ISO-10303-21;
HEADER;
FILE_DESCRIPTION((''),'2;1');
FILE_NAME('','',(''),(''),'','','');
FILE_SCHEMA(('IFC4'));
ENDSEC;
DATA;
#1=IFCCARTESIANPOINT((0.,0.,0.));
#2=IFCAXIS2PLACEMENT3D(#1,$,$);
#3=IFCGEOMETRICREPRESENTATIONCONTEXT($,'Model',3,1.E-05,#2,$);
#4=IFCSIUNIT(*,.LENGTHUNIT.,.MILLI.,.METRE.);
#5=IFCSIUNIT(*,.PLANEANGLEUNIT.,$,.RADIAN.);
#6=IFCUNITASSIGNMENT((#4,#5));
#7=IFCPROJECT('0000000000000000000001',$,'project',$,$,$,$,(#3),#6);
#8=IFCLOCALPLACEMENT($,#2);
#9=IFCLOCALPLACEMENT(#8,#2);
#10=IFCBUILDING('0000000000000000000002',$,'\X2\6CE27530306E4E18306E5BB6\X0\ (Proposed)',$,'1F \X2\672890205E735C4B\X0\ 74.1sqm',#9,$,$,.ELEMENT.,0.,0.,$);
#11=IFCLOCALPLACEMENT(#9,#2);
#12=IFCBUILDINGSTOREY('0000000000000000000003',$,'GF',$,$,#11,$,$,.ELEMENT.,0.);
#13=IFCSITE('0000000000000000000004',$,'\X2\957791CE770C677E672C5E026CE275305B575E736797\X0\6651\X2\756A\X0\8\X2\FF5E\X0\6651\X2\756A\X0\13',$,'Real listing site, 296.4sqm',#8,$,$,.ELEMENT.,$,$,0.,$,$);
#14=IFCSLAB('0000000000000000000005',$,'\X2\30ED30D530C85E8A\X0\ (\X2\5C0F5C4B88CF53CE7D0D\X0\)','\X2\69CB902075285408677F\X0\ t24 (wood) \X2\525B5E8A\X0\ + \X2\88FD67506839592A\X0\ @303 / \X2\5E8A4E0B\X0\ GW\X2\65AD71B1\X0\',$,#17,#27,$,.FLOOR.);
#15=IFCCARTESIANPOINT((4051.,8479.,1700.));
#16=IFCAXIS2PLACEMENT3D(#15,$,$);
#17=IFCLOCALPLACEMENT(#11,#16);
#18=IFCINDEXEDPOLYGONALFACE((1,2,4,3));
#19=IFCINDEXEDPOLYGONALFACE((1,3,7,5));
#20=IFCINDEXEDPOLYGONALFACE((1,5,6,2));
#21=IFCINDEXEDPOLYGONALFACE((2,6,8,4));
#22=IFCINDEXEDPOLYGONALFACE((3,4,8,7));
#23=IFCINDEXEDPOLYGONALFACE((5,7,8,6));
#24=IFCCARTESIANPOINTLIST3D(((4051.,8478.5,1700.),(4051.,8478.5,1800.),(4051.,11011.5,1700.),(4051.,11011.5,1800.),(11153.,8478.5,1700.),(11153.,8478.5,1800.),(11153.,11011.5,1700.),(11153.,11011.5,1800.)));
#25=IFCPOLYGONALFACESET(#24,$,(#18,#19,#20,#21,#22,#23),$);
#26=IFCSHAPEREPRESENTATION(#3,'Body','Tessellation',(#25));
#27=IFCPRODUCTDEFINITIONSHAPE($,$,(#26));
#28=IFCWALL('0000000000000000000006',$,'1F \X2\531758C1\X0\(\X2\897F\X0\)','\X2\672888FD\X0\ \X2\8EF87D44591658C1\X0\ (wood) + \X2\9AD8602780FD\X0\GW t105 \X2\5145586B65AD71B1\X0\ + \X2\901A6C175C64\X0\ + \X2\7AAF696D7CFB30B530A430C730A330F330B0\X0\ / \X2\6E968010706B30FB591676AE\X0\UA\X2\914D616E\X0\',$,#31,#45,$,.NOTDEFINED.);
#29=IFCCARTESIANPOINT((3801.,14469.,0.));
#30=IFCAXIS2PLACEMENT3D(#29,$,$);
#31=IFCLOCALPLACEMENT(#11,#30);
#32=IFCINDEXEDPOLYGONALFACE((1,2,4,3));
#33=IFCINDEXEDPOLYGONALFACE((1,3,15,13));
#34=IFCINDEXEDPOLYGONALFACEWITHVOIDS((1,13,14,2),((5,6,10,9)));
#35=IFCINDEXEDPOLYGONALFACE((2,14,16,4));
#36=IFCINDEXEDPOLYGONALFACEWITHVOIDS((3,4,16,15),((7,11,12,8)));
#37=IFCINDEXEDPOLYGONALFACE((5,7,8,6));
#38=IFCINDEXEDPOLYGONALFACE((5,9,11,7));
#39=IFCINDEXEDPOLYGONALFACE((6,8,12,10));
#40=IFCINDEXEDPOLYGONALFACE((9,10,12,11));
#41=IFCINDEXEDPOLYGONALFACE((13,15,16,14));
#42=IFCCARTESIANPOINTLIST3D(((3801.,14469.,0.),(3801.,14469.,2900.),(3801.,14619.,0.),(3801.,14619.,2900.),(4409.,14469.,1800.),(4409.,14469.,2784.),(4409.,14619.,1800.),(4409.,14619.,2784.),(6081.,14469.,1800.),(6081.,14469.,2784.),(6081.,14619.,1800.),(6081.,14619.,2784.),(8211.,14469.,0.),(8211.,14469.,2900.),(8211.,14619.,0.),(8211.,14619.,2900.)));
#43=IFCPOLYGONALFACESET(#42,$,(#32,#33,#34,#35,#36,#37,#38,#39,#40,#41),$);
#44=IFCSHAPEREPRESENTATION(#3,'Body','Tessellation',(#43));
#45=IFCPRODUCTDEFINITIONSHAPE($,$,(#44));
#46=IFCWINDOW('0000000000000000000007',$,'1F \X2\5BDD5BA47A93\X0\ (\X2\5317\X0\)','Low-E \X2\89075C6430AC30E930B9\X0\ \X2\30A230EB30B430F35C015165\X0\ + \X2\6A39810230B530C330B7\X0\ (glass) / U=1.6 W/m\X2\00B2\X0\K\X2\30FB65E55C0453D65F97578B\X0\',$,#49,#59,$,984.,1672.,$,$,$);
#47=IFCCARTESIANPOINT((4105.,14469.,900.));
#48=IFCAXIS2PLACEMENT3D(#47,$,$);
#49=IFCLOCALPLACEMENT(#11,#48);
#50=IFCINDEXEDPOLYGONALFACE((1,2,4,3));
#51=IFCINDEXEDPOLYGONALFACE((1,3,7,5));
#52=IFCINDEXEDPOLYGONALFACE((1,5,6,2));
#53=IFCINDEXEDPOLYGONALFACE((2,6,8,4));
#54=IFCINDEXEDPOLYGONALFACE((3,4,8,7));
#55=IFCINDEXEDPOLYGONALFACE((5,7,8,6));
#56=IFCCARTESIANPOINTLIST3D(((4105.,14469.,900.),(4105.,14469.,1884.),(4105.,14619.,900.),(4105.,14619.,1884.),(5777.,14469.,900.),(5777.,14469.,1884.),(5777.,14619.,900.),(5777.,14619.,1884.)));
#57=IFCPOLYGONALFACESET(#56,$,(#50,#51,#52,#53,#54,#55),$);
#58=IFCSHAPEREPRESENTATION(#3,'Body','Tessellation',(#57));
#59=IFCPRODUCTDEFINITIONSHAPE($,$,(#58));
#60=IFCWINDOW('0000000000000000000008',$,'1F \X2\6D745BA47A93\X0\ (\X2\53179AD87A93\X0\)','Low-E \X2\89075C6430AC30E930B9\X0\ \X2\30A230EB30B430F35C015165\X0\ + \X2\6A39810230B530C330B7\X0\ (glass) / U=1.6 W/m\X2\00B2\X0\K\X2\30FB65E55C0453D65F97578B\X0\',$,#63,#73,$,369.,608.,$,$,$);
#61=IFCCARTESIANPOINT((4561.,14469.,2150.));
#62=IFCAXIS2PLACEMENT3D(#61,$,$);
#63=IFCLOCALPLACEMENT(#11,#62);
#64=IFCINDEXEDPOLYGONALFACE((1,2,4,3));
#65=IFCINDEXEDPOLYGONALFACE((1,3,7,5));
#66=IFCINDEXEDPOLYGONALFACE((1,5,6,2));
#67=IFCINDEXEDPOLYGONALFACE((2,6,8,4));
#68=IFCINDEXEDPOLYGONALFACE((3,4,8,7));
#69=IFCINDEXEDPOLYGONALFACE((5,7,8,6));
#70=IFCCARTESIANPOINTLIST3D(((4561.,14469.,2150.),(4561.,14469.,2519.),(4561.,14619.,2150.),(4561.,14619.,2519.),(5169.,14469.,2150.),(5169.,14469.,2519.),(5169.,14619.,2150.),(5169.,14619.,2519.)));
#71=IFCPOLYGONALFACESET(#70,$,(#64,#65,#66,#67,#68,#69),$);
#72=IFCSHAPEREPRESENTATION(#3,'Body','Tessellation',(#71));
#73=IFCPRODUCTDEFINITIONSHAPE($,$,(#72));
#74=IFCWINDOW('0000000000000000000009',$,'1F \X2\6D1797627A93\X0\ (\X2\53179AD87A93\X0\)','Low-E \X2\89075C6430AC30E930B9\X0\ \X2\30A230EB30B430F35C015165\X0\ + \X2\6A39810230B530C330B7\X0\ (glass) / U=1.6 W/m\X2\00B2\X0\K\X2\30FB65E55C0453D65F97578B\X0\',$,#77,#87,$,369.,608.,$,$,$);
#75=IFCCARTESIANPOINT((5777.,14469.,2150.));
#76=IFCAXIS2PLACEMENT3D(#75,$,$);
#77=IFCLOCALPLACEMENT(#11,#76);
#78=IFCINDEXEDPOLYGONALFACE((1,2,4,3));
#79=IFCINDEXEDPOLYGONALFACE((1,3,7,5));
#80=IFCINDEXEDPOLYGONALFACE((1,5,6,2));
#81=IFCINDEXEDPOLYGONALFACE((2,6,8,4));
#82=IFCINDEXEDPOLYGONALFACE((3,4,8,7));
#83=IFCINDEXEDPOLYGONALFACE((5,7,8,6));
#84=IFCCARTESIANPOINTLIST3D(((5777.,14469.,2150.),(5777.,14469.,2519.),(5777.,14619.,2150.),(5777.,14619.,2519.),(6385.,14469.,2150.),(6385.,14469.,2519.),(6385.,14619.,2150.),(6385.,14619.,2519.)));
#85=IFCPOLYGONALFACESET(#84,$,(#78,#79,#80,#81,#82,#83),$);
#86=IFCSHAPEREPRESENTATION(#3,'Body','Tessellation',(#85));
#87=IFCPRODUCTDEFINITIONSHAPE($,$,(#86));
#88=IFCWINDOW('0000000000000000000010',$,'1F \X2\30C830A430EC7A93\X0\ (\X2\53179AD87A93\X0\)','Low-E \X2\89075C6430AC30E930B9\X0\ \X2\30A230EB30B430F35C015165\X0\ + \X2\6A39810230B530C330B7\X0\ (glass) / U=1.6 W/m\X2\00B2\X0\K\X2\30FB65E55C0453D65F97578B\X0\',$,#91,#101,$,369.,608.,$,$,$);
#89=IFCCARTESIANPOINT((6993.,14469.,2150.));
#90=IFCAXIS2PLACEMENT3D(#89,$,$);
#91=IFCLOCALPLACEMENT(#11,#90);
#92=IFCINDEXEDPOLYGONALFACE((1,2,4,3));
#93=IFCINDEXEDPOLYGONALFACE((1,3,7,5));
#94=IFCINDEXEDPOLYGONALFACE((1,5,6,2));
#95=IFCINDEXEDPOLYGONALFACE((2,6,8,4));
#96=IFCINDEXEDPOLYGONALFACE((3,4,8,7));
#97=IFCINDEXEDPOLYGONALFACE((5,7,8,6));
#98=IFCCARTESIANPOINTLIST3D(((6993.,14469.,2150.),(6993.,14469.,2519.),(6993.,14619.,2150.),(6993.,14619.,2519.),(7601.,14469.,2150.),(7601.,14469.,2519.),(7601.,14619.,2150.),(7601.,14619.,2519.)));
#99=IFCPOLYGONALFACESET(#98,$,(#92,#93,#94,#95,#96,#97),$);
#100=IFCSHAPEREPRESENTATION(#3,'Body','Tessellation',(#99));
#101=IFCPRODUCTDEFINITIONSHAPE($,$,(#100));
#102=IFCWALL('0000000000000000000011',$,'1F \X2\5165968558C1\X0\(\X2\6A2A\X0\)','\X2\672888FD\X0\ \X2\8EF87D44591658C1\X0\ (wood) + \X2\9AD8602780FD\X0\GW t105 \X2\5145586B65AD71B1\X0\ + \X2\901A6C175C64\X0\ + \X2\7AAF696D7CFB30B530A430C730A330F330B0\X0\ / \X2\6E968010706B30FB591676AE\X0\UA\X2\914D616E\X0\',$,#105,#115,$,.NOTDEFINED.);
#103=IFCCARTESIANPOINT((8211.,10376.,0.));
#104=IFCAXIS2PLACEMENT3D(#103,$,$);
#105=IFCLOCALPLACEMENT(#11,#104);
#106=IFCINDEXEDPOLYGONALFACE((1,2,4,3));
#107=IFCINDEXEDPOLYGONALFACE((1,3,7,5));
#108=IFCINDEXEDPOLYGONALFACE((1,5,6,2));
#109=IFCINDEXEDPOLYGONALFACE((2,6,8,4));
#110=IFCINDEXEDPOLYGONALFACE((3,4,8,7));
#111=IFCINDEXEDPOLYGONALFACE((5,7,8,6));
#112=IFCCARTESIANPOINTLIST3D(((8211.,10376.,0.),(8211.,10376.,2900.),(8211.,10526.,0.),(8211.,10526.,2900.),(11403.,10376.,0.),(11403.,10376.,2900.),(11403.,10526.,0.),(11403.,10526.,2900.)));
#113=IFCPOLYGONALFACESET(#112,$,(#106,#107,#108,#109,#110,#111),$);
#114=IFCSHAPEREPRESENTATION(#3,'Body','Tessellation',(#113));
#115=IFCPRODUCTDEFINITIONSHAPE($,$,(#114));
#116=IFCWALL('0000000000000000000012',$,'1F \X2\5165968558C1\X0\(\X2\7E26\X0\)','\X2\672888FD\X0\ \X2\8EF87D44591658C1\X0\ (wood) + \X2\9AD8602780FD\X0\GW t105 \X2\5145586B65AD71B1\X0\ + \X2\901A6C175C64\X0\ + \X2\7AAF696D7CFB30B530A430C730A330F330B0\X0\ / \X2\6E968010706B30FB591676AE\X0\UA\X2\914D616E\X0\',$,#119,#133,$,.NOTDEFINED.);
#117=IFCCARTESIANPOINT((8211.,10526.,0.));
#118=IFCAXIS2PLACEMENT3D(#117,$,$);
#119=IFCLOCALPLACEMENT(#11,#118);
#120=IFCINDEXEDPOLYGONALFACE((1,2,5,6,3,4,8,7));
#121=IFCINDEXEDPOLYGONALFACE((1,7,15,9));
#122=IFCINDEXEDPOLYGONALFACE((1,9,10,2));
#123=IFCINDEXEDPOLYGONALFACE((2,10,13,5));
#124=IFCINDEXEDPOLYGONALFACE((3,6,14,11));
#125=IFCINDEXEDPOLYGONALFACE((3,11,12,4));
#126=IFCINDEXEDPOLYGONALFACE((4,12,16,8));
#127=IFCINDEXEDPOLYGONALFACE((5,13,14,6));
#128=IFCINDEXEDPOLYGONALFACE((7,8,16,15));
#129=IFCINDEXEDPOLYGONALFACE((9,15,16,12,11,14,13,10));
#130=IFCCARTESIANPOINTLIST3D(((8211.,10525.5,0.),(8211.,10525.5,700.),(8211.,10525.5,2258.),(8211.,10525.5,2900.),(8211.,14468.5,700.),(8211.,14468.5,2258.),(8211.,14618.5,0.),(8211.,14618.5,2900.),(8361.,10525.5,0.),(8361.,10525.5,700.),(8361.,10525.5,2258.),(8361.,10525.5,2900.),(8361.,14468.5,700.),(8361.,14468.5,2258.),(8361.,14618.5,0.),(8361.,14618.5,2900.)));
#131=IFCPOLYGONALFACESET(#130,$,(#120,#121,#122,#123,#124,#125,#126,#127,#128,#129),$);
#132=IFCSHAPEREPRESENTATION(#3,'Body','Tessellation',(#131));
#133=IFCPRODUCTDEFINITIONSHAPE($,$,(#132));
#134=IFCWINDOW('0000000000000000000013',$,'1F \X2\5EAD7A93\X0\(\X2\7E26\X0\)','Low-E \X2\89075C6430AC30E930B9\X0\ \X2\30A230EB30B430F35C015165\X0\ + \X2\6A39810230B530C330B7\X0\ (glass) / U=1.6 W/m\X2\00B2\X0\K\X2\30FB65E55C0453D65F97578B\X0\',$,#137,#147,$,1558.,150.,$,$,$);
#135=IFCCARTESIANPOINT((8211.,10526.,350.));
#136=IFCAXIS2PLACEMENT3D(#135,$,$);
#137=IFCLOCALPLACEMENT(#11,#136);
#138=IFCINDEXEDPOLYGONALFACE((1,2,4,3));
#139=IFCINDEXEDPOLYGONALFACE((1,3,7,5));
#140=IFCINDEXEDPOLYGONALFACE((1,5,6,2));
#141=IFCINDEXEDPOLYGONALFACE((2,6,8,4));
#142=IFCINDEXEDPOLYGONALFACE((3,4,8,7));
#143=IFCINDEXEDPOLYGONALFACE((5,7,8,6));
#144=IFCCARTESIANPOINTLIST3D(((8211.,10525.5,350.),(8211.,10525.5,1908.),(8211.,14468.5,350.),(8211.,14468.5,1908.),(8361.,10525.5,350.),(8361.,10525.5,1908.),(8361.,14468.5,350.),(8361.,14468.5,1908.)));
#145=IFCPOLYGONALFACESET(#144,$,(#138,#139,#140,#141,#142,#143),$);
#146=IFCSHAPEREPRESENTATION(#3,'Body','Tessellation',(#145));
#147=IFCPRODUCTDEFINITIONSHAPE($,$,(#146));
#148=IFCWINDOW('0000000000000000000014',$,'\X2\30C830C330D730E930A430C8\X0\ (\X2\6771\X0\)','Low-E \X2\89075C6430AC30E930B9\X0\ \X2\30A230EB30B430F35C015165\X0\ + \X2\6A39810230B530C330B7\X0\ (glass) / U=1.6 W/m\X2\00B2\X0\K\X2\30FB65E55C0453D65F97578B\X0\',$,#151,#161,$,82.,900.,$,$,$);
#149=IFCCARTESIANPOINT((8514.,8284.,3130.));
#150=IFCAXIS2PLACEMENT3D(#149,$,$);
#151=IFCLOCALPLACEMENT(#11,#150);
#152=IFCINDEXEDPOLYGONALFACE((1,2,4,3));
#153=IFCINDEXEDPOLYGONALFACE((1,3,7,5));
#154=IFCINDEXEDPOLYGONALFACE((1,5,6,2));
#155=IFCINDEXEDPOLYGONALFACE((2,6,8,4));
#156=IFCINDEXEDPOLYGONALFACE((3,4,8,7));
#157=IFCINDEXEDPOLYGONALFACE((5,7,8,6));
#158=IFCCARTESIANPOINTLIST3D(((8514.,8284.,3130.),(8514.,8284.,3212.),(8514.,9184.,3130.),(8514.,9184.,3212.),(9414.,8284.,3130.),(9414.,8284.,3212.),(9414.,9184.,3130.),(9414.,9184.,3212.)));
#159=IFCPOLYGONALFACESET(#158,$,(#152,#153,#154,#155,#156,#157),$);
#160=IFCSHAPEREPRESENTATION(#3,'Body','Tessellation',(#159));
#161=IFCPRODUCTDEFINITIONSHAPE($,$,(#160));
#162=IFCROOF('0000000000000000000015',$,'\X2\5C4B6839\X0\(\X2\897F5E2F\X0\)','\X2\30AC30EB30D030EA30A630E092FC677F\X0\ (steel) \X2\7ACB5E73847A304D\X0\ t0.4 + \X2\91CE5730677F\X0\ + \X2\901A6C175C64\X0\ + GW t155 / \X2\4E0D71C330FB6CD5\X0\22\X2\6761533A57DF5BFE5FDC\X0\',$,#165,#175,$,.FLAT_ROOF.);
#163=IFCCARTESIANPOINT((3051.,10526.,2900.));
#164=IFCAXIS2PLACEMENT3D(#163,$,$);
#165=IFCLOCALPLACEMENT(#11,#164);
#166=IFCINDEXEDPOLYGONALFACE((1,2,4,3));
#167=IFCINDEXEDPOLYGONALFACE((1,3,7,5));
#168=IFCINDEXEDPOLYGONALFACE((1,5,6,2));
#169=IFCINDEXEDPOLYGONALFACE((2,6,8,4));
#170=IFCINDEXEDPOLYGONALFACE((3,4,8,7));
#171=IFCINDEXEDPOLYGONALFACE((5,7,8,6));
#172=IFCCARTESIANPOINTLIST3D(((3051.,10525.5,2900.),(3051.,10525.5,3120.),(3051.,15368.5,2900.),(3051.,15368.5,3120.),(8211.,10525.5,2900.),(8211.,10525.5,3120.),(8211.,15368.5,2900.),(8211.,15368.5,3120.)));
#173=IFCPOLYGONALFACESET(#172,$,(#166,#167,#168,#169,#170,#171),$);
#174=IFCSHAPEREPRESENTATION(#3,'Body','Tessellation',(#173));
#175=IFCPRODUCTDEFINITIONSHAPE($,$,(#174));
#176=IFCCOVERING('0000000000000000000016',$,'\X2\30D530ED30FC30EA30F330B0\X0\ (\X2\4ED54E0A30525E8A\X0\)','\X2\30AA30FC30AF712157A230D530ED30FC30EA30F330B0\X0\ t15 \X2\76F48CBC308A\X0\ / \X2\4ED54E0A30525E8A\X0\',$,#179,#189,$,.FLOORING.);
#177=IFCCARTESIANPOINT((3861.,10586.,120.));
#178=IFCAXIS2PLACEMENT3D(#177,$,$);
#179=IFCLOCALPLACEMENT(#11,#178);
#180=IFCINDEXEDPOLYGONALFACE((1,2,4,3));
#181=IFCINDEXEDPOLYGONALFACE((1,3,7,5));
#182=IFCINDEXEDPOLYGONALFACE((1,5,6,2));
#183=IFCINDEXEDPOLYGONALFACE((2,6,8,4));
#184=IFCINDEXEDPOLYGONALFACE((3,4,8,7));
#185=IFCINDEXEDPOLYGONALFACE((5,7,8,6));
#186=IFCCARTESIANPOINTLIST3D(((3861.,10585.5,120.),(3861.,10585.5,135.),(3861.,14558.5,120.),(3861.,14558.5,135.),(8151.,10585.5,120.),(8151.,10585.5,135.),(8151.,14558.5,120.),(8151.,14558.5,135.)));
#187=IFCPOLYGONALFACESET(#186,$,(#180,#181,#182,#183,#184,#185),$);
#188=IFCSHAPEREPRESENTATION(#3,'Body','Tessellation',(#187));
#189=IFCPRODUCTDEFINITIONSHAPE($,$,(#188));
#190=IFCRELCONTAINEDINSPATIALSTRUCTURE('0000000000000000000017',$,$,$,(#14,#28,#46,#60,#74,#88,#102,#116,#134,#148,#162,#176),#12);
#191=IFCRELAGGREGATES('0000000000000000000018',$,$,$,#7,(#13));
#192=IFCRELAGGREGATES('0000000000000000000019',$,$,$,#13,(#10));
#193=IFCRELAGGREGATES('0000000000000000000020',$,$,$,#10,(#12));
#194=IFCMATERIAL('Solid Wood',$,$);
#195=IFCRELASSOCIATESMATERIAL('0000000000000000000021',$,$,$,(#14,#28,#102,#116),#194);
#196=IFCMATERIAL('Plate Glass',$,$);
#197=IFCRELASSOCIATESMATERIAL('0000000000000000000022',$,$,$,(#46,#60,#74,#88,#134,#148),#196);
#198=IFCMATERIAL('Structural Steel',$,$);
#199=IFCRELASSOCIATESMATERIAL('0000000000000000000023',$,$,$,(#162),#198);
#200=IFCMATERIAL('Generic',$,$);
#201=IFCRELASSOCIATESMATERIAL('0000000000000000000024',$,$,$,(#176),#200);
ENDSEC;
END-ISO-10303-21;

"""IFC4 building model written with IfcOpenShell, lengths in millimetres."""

from ifc_helpers import new_model, si_unit, frame, frame_2d, origin, place, context, project, spatial, rectangle, extrude, material, element, fill, save


model = new_model("IFC4")

# Units and contexts
model_context = context("Model", 3, precision=1e-05, world=origin())
ifc_project = project(units=[si_unit("LENGTHUNIT", "METRE", prefix="MILLI"), si_unit("PLANEANGLEUNIT", "RADIAN")], contexts=[model_context])

# Site, building, storey
site_placement = place(None, origin())
site = spatial("IfcSite", under=ifc_project, at=site_placement, Name="長野県松本市波田字平林6651番8～6651番13", ObjectType="Real listing site, 296.4sqm", CompositionType="ELEMENT", RefElevation=0.0)
building_placement = place(site_placement, origin())
building = spatial("IfcBuilding", under=site, at=building_placement, Name="波田の丘の家 (Proposed)", ObjectType="1F 木造平屋 74.1sqm", CompositionType="ELEMENT", ElevationOfRefHeight=0.0, ElevationOfTerrain=0.0)
storey_placement = place(building_placement, origin())
storey = spatial("IfcBuildingStorey", under=building, at=storey_placement, Name="GF", CompositionType="ELEMENT", Elevation=0.0)

# Slab
ifc_material_1 = material(Name="Solid Wood")
slab_1_placement = place(storey_placement, frame((4051.0, 8479.0, 1700.0)))
element("IfcSlab", 1, at=slab_1_placement, inside=storey, material=ifc_material_1, Name="ロフト床 (小屋裏収納)", Description="構造用合板 t24 (wood) 剛床 + 製材根太 @303 / 床下 GW断熱", PredefinedType="FLOOR", context=model_context, shape_type="SweptSolid", body=[
    extrude(rectangle(XDim=7102.0, YDim=2533.0, at=frame_2d((3551.0, 1266.0))), frame((4051.0, 8479.0, 1700.0)), (0.0, 0.0, 1.0), 100.0),
])

# Wall, openings, windows
wall_1_placement = place(storey_placement, frame((3801.0, 14469.0, 0.0)))
wall_1 = element("IfcWall", 2, at=wall_1_placement, inside=storey, material=ifc_material_1, Name="1F 北壁(西)", Description="木製 軸組外壁 (wood) + 高性能GW t105 充填断熱 + 通気層 + 窯業系サイディング / 準耐火・外皮UA配慮", PredefinedType="NOTDEFINED", context=model_context, shape_type="SweptSolid", body=[
    extrude(rectangle(XDim=4410.0, YDim=150.0, at=frame_2d((2205.0, 75.0))), frame((3801.0, 14469.0, 0.0)), (0.0, 0.0, 1.0), 2900.0),
])
opening_1_placement = place(storey_placement, frame((4105.0, 14469.0, 900.0)))
opening_1 = element("IfcOpeningElement", 3, at=opening_1_placement, cuts=wall_1, PredefinedType="NOTDEFINED", context=model_context, shape_type="SweptSolid", body=[
    extrude(rectangle(XDim=1672.0, YDim=150.0, at=frame_2d((836.0, 75.0))), frame((4105.0, 14469.0, 900.0)), (0.0, 0.0, 1.0), 984.0),
])
opening_2_placement = place(storey_placement, frame((4561.0, 14469.0, 2150.0)))
opening_2 = element("IfcOpeningElement", 4, at=opening_2_placement, cuts=wall_1, PredefinedType="NOTDEFINED", context=model_context, shape_type="SweptSolid", body=[
    extrude(rectangle(XDim=608.0, YDim=150.0, at=frame_2d((304.0, 75.0))), frame((4561.0, 14469.0, 2150.0)), (0.0, 0.0, 1.0), 369.0),
])
opening_3_placement = place(storey_placement, frame((5777.0, 14469.0, 2150.0)))
opening_3 = element("IfcOpeningElement", 5, at=opening_3_placement, cuts=wall_1, PredefinedType="NOTDEFINED", context=model_context, shape_type="SweptSolid", body=[
    extrude(rectangle(XDim=608.0, YDim=150.0, at=frame_2d((304.0, 75.0))), frame((5777.0, 14469.0, 2150.0)), (0.0, 0.0, 1.0), 369.0),
])
opening_4_placement = place(storey_placement, frame((6993.0, 14469.0, 2150.0)))
opening_4 = element("IfcOpeningElement", 6, at=opening_4_placement, cuts=wall_1, PredefinedType="NOTDEFINED", context=model_context, shape_type="SweptSolid", body=[
    extrude(rectangle(XDim=608.0, YDim=150.0, at=frame_2d((304.0, 75.0))), frame((6993.0, 14469.0, 2150.0)), (0.0, 0.0, 1.0), 369.0),
])
ifc_material_2 = material(Name="Plate Glass")
window_1_placement = place(storey_placement, frame((4105.0, 14469.0, 900.0)))
window_1 = element("IfcWindow", 7, at=window_1_placement, inside=storey, material=ifc_material_2, Name="1F 寝室窓 (北)", Description="Low-E 複層ガラス アルゴン封入 + 樹脂サッシ (glass) / U=1.6 W/m²K・日射取得型", OverallHeight=984.0, OverallWidth=1672.0, context=model_context, shape_type="SweptSolid", body=[
    extrude(rectangle(XDim=1672.0, YDim=150.0, at=frame_2d((836.0, 75.0))), frame((4105.0, 14469.0, 900.0)), (0.0, 0.0, 1.0), 984.0),
])
fill(opening_1, window_1)
window_2_placement = place(storey_placement, frame((4561.0, 14469.0, 2150.0)))
window_2 = element("IfcWindow", 8, at=window_2_placement, inside=storey, material=ifc_material_2, Name="1F 浴室窓 (北高窓)", Description="Low-E 複層ガラス アルゴン封入 + 樹脂サッシ (glass) / U=1.6 W/m²K・日射取得型", OverallHeight=369.0, OverallWidth=608.0, context=model_context, shape_type="SweptSolid", body=[
    extrude(rectangle(XDim=608.0, YDim=150.0, at=frame_2d((304.0, 75.0))), frame((4561.0, 14469.0, 2150.0)), (0.0, 0.0, 1.0), 369.0),
])
fill(opening_2, window_2)
window_3_placement = place(storey_placement, frame((5777.0, 14469.0, 2150.0)))
window_3 = element("IfcWindow", 9, at=window_3_placement, inside=storey, material=ifc_material_2, Name="1F 洗面窓 (北高窓)", Description="Low-E 複層ガラス アルゴン封入 + 樹脂サッシ (glass) / U=1.6 W/m²K・日射取得型", OverallHeight=369.0, OverallWidth=608.0, context=model_context, shape_type="SweptSolid", body=[
    extrude(rectangle(XDim=608.0, YDim=150.0, at=frame_2d((304.0, 75.0))), frame((5777.0, 14469.0, 2150.0)), (0.0, 0.0, 1.0), 369.0),
])
fill(opening_3, window_3)
window_4_placement = place(storey_placement, frame((6993.0, 14469.0, 2150.0)))
window_4 = element("IfcWindow", 10, at=window_4_placement, inside=storey, material=ifc_material_2, Name="1F トイレ窓 (北高窓)", Description="Low-E 複層ガラス アルゴン封入 + 樹脂サッシ (glass) / U=1.6 W/m²K・日射取得型", OverallHeight=369.0, OverallWidth=608.0, context=model_context, shape_type="SweptSolid", body=[
    extrude(rectangle(XDim=608.0, YDim=150.0, at=frame_2d((304.0, 75.0))), frame((6993.0, 14469.0, 2150.0)), (0.0, 0.0, 1.0), 369.0),
])
fill(opening_4, window_4)

# Wall
wall_2_placement = place(storey_placement, frame((8211.0, 10376.0, 0.0)))
element("IfcWall", 11, at=wall_2_placement, inside=storey, material=ifc_material_1, Name="1F 入隅壁(横)", Description="木製 軸組外壁 (wood) + 高性能GW t105 充填断熱 + 通気層 + 窯業系サイディング / 準耐火・外皮UA配慮", PredefinedType="NOTDEFINED", context=model_context, shape_type="SweptSolid", body=[
    extrude(rectangle(XDim=3192.0, YDim=150.0, at=frame_2d((1596.0, 75.0))), frame((8211.0, 10376.0, 0.0)), (0.0, 0.0, 1.0), 2900.0),
])

# Wall, opening, window
wall_3_placement = place(storey_placement, frame((8211.0, 10526.0, 0.0)))
wall_3 = element("IfcWall", 12, at=wall_3_placement, inside=storey, material=ifc_material_1, Name="1F 入隅壁(縦)", Description="木製 軸組外壁 (wood) + 高性能GW t105 充填断熱 + 通気層 + 窯業系サイディング / 準耐火・外皮UA配慮", PredefinedType="NOTDEFINED", context=model_context, shape_type="SweptSolid", body=[
    extrude(rectangle(XDim=150.0, YDim=4093.0, at=frame_2d((75.0, 2046.0))), frame((8211.0, 10526.0, 0.0)), (0.0, 0.0, 1.0), 2900.0),
])
opening_5_placement = place(storey_placement, frame((8211.0, 10526.0, 350.0)))
opening_5 = element("IfcOpeningElement", 13, at=opening_5_placement, cuts=wall_3, PredefinedType="NOTDEFINED", context=model_context, shape_type="SweptSolid", body=[
    extrude(rectangle(XDim=150.0, YDim=3943.0, at=frame_2d((75.0, 1971.0))), frame((8211.0, 10526.0, 350.0)), (0.0, 0.0, 1.0), 1558.0),
])
window_5_placement = place(storey_placement, frame((8211.0, 10526.0, 350.0)))
window_5 = element("IfcWindow", 14, at=window_5_placement, inside=storey, material=ifc_material_2, Name="1F 庭窓(縦)", Description="Low-E 複層ガラス アルゴン封入 + 樹脂サッシ (glass) / U=1.6 W/m²K・日射取得型", OverallHeight=1558.0, OverallWidth=150.0, context=model_context, shape_type="SweptSolid", body=[
    extrude(rectangle(XDim=150.0, YDim=3943.0, at=frame_2d((75.0, 1971.0))), frame((8211.0, 10526.0, 350.0)), (0.0, 0.0, 1.0), 1558.0),
])
fill(opening_5, window_5)

# Window
window_6_placement = place(storey_placement, frame((8514.0, 8284.0, 3130.0)))
element("IfcWindow", 15, at=window_6_placement, inside=storey, material=ifc_material_2, Name="トップライト (東)", Description="Low-E 複層ガラス アルゴン封入 + 樹脂サッシ (glass) / U=1.6 W/m²K・日射取得型", OverallHeight=82.0, OverallWidth=900.0, context=model_context, shape_type="SweptSolid", body=[
    extrude(rectangle(XDim=900.0, YDim=900.0, at=frame_2d((450.0, 450.0))), frame((8514.0, 8284.0, 3130.0)), (0.0, 0.0, 1.0), 82.0),
])

# Roof
ifc_material_3 = material(Name="Structural Steel")
roof_placement = place(storey_placement, frame((3051.0, 10526.0, 2900.0)))
element("IfcRoof", 16, at=roof_placement, inside=storey, material=ifc_material_3, Name="屋根(西帯)", Description="ガルバリウム鋼板 (steel) 立平葺き t0.4 + 野地板 + 通気層 + GW t155 / 不燃・法22条区域対応", PredefinedType="FLAT_ROOF", context=model_context, shape_type="SweptSolid", body=[
    extrude(rectangle(XDim=5160.0, YDim=4843.0, at=frame_2d((2580.0, 2421.0))), frame((3051.0, 10526.0, 2900.0)), (0.0, 0.0, 1.0), 220.0),
])

# Covering
ifc_material_4 = material(Name="Generic")
covering_placement = place(storey_placement, frame((3861.0, 10586.0, 120.0)))
element("IfcCovering", 17, at=covering_placement, inside=storey, material=ifc_material_4, Name="フローリング (仕上げ床)", Description="オーク無垢フローリング t15 直貼り / 仕上げ床", PredefinedType="FLOORING", context=model_context, shape_type="SweptSolid", body=[
    extrude(rectangle(XDim=4290.0, YDim=3973.0, at=frame_2d((2145.0, 1986.0))), frame((3861.0, 10586.0, 120.0)), (0.0, 0.0, 1.0), 15.0),
])

save(model, "model.ifc")
